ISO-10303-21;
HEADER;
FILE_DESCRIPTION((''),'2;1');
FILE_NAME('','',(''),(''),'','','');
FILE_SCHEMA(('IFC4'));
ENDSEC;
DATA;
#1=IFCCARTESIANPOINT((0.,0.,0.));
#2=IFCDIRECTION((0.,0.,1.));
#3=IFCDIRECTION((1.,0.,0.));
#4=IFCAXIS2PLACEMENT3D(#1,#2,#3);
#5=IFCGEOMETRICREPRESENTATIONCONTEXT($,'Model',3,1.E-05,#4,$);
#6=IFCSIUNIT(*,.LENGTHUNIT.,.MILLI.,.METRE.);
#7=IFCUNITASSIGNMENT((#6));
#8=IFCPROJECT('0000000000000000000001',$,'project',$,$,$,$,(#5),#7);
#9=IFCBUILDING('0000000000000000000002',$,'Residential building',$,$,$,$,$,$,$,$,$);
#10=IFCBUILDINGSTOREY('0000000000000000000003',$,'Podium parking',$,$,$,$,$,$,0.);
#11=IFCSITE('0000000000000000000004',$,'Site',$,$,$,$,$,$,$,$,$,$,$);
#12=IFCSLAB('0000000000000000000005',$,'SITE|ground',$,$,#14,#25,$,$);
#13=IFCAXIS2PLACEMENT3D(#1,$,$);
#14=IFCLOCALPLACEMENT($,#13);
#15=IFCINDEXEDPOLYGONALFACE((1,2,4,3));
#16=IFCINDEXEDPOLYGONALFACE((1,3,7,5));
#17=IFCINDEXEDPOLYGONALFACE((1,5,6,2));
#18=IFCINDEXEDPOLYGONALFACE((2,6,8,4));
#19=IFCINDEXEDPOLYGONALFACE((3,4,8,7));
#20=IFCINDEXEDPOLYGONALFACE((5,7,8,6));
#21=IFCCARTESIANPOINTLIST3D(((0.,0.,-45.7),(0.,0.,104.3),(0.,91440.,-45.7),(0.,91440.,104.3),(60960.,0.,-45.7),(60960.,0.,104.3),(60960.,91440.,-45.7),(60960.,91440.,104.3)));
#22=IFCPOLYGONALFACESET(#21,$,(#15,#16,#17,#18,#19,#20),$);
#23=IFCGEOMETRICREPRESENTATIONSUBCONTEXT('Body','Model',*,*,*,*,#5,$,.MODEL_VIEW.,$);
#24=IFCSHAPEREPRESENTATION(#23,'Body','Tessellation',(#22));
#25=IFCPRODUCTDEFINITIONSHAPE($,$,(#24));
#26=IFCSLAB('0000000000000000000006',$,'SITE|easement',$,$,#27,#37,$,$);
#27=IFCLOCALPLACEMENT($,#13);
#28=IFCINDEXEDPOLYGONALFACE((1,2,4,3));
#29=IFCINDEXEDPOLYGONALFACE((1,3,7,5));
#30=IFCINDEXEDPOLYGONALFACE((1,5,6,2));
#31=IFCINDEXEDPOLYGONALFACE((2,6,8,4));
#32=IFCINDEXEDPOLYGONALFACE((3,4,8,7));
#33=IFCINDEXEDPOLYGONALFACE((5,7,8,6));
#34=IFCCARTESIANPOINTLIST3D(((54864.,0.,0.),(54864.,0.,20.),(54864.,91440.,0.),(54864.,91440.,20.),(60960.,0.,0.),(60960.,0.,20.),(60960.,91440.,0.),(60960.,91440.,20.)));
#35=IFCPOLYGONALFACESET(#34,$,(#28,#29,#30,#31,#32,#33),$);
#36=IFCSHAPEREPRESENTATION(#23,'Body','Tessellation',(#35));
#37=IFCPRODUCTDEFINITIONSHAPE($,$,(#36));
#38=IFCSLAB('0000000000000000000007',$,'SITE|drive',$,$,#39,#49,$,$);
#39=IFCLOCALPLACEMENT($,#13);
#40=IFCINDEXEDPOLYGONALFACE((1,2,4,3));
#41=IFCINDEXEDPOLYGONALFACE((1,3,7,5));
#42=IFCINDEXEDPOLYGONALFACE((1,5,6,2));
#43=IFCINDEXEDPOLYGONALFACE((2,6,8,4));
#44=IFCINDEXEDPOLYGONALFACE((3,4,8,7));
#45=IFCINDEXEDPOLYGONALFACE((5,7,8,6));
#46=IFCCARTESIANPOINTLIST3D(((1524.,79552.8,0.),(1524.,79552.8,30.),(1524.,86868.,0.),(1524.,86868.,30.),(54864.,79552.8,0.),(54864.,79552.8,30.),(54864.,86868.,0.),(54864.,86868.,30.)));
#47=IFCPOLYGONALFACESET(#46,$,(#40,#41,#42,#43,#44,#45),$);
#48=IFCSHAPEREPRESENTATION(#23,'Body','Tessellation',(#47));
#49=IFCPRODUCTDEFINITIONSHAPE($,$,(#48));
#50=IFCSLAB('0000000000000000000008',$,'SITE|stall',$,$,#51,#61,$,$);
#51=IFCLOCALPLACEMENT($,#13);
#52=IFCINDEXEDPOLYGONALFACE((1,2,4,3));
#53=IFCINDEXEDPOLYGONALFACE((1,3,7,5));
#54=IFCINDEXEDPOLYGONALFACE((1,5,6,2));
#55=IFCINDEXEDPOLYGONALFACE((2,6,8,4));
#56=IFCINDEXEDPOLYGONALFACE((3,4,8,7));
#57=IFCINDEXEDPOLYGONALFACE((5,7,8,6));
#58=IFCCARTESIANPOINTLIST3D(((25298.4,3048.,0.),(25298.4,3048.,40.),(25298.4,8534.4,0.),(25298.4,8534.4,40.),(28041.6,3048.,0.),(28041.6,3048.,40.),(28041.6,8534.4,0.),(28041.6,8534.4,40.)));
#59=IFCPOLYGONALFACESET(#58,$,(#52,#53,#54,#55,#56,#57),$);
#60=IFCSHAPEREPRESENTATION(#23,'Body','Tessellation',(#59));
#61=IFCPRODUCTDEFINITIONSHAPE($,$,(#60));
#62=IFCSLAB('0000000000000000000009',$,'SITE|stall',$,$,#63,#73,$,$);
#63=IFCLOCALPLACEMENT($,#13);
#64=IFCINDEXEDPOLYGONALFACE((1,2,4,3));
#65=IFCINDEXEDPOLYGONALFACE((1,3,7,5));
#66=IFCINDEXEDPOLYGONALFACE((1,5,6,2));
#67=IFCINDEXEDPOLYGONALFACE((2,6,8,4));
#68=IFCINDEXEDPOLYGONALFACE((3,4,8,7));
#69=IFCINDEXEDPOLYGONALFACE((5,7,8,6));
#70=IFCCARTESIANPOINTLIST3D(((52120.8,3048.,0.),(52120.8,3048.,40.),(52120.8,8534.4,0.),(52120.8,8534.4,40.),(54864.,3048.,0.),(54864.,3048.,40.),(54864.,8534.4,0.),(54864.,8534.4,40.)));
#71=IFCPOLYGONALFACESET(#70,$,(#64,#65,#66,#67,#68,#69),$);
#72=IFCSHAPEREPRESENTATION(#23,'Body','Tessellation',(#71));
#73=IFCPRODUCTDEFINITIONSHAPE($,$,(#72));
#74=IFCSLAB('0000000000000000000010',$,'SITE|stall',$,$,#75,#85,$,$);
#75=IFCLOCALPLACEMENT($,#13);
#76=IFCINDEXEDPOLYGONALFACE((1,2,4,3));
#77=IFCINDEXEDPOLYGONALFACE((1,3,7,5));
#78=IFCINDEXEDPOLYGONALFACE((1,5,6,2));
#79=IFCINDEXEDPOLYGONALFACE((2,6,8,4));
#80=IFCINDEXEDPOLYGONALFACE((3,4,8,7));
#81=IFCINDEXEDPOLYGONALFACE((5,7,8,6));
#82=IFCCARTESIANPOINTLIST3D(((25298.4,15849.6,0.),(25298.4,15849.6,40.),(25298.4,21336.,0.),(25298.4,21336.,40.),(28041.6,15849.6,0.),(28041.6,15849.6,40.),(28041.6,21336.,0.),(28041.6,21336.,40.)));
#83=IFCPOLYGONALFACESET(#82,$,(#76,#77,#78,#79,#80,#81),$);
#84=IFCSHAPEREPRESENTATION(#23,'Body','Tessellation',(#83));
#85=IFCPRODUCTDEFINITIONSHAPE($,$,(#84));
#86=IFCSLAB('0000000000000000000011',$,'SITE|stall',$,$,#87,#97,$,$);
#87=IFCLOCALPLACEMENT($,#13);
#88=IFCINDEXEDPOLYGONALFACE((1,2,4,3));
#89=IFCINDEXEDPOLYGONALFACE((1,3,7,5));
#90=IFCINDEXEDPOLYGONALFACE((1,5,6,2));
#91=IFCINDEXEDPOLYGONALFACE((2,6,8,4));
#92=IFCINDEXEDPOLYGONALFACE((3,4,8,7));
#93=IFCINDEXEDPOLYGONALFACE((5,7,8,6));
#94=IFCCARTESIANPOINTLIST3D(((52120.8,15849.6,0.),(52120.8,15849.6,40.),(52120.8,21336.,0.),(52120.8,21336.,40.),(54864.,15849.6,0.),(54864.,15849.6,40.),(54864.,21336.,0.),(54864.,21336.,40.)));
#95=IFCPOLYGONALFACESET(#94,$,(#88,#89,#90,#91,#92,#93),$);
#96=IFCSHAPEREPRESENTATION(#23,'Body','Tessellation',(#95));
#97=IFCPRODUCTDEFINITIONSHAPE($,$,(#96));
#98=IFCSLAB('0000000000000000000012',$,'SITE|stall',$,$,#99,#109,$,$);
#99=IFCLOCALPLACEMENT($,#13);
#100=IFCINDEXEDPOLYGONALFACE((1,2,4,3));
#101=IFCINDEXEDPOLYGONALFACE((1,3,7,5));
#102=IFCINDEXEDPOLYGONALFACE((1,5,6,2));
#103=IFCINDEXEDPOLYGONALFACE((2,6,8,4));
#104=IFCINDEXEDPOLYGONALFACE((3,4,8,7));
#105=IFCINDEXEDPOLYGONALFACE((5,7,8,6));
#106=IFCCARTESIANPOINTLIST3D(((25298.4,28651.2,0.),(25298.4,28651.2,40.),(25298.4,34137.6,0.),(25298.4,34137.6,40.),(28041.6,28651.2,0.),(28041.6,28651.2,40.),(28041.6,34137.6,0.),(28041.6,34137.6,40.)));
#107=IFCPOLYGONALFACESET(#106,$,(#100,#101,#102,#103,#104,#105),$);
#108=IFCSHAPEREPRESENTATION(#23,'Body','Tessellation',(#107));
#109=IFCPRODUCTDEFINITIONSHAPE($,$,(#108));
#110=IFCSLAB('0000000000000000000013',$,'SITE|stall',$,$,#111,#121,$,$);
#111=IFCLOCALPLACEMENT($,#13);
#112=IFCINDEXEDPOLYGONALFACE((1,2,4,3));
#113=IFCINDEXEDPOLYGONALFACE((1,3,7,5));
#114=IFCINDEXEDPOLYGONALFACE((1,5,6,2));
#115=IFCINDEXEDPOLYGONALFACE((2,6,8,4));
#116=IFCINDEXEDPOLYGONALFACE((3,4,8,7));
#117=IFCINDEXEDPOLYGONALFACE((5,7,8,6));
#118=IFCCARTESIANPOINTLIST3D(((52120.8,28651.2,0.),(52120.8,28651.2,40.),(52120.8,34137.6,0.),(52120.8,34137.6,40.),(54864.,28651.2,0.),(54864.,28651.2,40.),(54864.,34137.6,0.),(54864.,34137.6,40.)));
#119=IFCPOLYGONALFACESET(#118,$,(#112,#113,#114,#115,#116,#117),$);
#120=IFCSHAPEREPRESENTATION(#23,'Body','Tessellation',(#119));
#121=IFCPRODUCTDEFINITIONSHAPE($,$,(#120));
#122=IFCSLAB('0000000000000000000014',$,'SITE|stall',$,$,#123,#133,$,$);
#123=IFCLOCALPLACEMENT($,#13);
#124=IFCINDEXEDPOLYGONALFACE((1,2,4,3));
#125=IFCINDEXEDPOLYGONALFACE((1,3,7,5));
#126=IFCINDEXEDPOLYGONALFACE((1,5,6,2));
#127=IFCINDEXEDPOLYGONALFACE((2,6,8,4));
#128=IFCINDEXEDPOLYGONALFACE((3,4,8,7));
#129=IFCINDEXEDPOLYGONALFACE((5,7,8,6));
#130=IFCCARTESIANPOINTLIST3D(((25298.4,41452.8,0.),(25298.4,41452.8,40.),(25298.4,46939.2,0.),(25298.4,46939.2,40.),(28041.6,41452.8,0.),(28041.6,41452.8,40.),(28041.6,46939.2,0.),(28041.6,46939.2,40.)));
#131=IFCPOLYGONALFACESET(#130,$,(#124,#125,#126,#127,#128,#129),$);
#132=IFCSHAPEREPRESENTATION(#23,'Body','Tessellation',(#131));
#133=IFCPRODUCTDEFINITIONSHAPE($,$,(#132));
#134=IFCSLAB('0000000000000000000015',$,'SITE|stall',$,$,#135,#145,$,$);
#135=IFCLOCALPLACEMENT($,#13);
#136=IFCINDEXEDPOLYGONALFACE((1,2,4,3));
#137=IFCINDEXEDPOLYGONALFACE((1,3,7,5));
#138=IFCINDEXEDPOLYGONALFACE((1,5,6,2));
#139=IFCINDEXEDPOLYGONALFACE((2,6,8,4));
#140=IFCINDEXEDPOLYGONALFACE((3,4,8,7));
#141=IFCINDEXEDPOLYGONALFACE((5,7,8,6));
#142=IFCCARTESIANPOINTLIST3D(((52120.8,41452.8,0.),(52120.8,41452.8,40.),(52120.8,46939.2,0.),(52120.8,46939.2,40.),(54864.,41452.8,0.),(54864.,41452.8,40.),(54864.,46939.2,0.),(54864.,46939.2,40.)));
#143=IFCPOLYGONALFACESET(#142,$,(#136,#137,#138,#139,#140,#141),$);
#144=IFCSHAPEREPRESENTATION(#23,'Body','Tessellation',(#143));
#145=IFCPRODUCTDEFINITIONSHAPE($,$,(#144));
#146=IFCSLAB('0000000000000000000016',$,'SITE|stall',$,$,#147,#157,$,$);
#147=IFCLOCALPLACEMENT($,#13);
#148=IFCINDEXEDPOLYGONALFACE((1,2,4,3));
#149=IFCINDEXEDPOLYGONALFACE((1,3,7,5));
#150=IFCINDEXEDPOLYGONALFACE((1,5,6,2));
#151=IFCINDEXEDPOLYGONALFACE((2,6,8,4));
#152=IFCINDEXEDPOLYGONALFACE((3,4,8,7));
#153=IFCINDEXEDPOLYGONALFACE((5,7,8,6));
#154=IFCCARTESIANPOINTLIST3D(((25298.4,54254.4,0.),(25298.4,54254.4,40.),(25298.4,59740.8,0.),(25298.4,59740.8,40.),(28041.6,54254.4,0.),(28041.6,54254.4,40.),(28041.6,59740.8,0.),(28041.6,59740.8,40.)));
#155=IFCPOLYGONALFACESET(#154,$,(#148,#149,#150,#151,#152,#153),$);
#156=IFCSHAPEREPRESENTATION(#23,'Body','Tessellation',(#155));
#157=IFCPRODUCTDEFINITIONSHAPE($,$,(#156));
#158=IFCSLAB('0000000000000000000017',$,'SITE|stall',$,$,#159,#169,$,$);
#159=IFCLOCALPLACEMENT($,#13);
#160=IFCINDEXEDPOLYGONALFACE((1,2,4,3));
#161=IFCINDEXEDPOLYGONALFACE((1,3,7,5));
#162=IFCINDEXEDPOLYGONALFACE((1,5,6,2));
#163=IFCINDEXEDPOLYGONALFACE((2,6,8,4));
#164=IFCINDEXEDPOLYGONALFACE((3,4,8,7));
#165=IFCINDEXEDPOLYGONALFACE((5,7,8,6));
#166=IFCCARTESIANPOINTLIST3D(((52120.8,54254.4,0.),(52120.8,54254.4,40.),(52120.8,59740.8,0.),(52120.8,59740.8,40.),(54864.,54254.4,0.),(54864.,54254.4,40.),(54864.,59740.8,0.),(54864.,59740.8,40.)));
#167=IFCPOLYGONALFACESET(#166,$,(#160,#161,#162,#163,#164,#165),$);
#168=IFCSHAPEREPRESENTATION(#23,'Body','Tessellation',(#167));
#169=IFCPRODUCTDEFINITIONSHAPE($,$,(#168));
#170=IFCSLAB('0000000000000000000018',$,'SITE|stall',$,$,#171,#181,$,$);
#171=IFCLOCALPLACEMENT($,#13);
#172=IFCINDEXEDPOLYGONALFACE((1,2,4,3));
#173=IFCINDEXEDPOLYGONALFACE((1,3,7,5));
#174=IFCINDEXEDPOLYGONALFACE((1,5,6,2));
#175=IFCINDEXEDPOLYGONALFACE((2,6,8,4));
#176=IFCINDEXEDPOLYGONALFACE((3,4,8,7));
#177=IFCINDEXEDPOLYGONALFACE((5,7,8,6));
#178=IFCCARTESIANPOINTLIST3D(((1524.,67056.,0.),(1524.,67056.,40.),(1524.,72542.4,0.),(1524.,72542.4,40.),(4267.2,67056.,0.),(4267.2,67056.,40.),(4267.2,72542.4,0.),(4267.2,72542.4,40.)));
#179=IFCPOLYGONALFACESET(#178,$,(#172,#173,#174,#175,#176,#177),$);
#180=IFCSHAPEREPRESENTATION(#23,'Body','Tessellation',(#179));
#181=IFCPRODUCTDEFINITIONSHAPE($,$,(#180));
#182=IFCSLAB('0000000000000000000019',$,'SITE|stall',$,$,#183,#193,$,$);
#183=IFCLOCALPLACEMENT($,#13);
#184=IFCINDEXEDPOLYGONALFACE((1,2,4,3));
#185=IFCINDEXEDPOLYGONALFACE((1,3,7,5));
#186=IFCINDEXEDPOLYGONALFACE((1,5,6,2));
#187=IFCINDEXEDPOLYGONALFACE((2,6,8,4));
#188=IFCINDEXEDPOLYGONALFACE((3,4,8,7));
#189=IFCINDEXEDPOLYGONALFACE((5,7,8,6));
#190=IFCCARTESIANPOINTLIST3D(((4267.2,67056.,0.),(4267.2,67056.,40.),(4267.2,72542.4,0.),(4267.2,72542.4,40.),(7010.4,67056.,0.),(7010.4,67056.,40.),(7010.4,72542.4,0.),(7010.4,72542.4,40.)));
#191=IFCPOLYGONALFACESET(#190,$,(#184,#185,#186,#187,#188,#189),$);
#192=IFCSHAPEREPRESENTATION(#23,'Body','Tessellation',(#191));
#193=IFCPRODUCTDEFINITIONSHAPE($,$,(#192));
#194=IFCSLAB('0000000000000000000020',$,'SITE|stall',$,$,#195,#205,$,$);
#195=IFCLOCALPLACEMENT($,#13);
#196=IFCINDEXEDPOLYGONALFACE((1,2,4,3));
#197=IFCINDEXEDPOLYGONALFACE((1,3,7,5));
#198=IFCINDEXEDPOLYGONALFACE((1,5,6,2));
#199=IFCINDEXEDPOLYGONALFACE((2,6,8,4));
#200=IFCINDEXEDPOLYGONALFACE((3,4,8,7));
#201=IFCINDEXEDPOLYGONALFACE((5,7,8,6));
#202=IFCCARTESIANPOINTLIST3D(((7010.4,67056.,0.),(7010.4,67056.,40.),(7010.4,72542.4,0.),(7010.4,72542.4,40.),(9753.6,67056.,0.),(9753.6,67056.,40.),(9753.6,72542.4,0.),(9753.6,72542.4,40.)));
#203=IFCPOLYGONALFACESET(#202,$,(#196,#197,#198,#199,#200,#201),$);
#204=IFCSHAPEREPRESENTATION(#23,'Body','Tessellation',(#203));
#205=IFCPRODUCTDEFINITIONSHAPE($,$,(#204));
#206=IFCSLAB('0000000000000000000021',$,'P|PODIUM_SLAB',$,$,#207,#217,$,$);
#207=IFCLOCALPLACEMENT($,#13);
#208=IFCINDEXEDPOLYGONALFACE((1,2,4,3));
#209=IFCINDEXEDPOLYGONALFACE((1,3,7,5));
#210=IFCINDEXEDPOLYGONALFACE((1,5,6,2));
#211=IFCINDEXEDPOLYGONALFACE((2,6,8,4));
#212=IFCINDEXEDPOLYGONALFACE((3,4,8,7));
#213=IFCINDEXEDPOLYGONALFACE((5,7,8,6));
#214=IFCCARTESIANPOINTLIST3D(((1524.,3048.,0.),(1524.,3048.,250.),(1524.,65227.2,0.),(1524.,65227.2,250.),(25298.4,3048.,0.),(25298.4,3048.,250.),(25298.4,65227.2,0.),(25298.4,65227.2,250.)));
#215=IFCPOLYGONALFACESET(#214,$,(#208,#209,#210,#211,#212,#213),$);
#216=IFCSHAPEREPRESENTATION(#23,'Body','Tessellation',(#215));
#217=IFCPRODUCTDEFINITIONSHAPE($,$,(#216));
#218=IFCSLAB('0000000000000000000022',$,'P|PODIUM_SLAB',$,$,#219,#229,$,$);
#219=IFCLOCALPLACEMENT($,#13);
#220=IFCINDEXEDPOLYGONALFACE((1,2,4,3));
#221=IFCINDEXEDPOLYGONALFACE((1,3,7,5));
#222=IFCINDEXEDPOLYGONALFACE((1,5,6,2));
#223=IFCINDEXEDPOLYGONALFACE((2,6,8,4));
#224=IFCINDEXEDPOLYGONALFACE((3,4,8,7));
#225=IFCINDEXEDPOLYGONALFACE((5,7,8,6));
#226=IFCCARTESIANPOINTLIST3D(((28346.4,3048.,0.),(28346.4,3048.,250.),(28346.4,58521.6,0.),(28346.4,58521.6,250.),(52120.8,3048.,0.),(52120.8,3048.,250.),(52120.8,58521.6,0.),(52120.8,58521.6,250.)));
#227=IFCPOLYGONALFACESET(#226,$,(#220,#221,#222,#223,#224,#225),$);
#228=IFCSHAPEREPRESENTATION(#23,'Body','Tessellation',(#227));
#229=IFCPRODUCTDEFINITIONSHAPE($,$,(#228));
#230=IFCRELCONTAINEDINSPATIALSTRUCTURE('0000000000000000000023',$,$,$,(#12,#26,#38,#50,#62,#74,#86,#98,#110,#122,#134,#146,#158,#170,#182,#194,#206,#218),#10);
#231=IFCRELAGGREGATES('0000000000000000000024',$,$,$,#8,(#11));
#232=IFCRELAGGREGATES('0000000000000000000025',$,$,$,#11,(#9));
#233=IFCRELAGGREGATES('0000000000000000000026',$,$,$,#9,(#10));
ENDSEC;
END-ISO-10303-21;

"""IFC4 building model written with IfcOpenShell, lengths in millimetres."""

from ifc_helpers import new_model, si_unit, frame, origin_with_axes, place, context, subcontext, project, spatial, indexed_curve, outline, extrude, element, save


model = new_model("IFC4")

# Units and contexts
model_context = context("Model", 3, precision=1e-05, world=origin_with_axes())
body_context = subcontext(model_context, "Body", "Model", "MODEL_VIEW")
ifc_project = project(units=[si_unit("LENGTHUNIT", "METRE", prefix="MILLI")], contexts=[model_context])

# Site, building, storey
site = spatial("IfcSite", under=ifc_project, Name="Site")
building = spatial("IfcBuilding", under=site, Name="Residential building")
storey = spatial("IfcBuildingStorey", under=building, Name="Podium parking", Elevation=0.0)

# Slabs
slab_1_placement = place(None, frame((0.0, 0.0, -45.7), z_axis=(0.0, 0.0, 1.0), x_axis=(1.0, 0.0, 0.0)))
element("IfcSlab", 1, at=slab_1_placement, inside=storey, Name="SITE|ground", context=body_context, shape_type="SweptSolid", body=[
    extrude(outline(indexed_curve([(0.0, 0.0), (60960.0, 0.0), (60960.0, 91440.0), (0.0, 91440.0), (0.0, 0.0)])), None, (0.0, 0.0, 1.0), 150.0),
])
slab_2_placement = place(None, frame((54864.0, 0.0, 0.0), z_axis=(0.0, 0.0, 1.0), x_axis=(1.0, 0.0, 0.0)))
element("IfcSlab", 2, at=slab_2_placement, inside=storey, Name="SITE|easement", context=body_context, shape_type="SweptSolid", body=[
    extrude(outline(indexed_curve([(0.0, 0.0), (6096.0, 0.0), (6096.0, 91440.0), (0.0, 91440.0), (0.0, 0.0)])), None, (0.0, 0.0, 1.0), 20.0),
])
slab_3_placement = place(None, frame((1524.0, 79552.8, 0.0), z_axis=(0.0, 0.0, 1.0), x_axis=(1.0, 0.0, 0.0)))
element("IfcSlab", 3, at=slab_3_placement, inside=storey, Name="SITE|drive", context=body_context, shape_type="SweptSolid", body=[
    extrude(outline(indexed_curve([(0.0, 0.0), (53340.0, 0.0), (53340.0, 7315.2), (0.0, 7315.2), (0.0, 0.0)])), None, (0.0, 0.0, 1.0), 30.0),
])
for number, where, z_axis, x_axis, name in (
    (4, (25298.4, 3048.0, 0.0), (0.0, 0.0, 1.0), (1.0, 0.0, 0.0), "SITE|stall"),
    (5, (52120.8, 3048.0, 0.0), (0.0, 0.0, 1.0), (1.0, 0.0, 0.0), "SITE|stall"),
    (6, (25298.4, 15849.6, 0.0), (0.0, 0.0, 1.0), (1.0, 0.0, 0.0), "SITE|stall"),
    (7, (52120.8, 15849.6, 0.0), (0.0, 0.0, 1.0), (1.0, 0.0, 0.0), "SITE|stall"),
    (8, (25298.4, 28651.2, 0.0), (0.0, 0.0, 1.0), (1.0, 0.0, 0.0), "SITE|stall"),
    (9, (52120.8, 28651.2, 0.0), (0.0, 0.0, 1.0), (1.0, 0.0, 0.0), "SITE|stall"),
    (10, (25298.4, 41452.8, 0.0), (0.0, 0.0, 1.0), (1.0, 0.0, 0.0), "SITE|stall"),
    (11, (52120.8, 41452.8, 0.0), (0.0, 0.0, 1.0), (1.0, 0.0, 0.0), "SITE|stall"),
    (12, (25298.4, 54254.4, 0.0), (0.0, 0.0, 1.0), (1.0, 0.0, 0.0), "SITE|stall"),
    (13, (52120.8, 54254.4, 0.0), (0.0, 0.0, 1.0), (1.0, 0.0, 0.0), "SITE|stall"),
    (14, (1524.0, 67056.0, 0.0), (0.0, 0.0, 1.0), (1.0, 0.0, 0.0), "SITE|stall"),
    (15, (4267.2, 67056.0, 0.0), (0.0, 0.0, 1.0), (1.0, 0.0, 0.0), "SITE|stall"),
    (16, (7010.4, 67056.0, 0.0), (0.0, 0.0, 1.0), (1.0, 0.0, 0.0), "SITE|stall"),
):
    element("IfcSlab", number, at=place(None, frame(where, z_axis=z_axis, x_axis=x_axis)), inside=storey, Name=name, context=body_context, shape_type="SweptSolid", body=[
        extrude(outline(indexed_curve([(0.0, 0.0), (2743.2, 0.0), (2743.2, 5486.4), (0.0, 5486.4), (0.0, 0.0)])), None, (0.0, 0.0, 1.0), 40.0),
    ])
slab_4_placement = place(None, frame((1524.0, 3048.0, 0.0), z_axis=(0.0, 0.0, 1.0), x_axis=(1.0, 0.0, 0.0)))
element("IfcSlab", 17, at=slab_4_placement, inside=storey, Name="P|PODIUM_SLAB", context=body_context, shape_type="SweptSolid", body=[
    extrude(outline(indexed_curve([(0.0, 0.0), (23774.4, 0.0), (23774.4, 62179.2), (0.0, 62179.2), (0.0, 0.0)])), None, (0.0, 0.0, 1.0), 250.0),
])
slab_5_placement = place(None, frame((28346.4, 3048.0, 0.0), z_axis=(0.0, 0.0, 1.0), x_axis=(1.0, 0.0, 0.0)))
element("IfcSlab", 18, at=slab_5_placement, inside=storey, Name="P|PODIUM_SLAB", context=body_context, shape_type="SweptSolid", body=[
    extrude(outline(indexed_curve([(0.0, 0.0), (23774.4, 0.0), (23774.4, 55473.6), (0.0, 55473.6), (0.0, 0.0)])), None, (0.0, 0.0, 1.0), 250.0),
])

save(model, "model.ifc")
